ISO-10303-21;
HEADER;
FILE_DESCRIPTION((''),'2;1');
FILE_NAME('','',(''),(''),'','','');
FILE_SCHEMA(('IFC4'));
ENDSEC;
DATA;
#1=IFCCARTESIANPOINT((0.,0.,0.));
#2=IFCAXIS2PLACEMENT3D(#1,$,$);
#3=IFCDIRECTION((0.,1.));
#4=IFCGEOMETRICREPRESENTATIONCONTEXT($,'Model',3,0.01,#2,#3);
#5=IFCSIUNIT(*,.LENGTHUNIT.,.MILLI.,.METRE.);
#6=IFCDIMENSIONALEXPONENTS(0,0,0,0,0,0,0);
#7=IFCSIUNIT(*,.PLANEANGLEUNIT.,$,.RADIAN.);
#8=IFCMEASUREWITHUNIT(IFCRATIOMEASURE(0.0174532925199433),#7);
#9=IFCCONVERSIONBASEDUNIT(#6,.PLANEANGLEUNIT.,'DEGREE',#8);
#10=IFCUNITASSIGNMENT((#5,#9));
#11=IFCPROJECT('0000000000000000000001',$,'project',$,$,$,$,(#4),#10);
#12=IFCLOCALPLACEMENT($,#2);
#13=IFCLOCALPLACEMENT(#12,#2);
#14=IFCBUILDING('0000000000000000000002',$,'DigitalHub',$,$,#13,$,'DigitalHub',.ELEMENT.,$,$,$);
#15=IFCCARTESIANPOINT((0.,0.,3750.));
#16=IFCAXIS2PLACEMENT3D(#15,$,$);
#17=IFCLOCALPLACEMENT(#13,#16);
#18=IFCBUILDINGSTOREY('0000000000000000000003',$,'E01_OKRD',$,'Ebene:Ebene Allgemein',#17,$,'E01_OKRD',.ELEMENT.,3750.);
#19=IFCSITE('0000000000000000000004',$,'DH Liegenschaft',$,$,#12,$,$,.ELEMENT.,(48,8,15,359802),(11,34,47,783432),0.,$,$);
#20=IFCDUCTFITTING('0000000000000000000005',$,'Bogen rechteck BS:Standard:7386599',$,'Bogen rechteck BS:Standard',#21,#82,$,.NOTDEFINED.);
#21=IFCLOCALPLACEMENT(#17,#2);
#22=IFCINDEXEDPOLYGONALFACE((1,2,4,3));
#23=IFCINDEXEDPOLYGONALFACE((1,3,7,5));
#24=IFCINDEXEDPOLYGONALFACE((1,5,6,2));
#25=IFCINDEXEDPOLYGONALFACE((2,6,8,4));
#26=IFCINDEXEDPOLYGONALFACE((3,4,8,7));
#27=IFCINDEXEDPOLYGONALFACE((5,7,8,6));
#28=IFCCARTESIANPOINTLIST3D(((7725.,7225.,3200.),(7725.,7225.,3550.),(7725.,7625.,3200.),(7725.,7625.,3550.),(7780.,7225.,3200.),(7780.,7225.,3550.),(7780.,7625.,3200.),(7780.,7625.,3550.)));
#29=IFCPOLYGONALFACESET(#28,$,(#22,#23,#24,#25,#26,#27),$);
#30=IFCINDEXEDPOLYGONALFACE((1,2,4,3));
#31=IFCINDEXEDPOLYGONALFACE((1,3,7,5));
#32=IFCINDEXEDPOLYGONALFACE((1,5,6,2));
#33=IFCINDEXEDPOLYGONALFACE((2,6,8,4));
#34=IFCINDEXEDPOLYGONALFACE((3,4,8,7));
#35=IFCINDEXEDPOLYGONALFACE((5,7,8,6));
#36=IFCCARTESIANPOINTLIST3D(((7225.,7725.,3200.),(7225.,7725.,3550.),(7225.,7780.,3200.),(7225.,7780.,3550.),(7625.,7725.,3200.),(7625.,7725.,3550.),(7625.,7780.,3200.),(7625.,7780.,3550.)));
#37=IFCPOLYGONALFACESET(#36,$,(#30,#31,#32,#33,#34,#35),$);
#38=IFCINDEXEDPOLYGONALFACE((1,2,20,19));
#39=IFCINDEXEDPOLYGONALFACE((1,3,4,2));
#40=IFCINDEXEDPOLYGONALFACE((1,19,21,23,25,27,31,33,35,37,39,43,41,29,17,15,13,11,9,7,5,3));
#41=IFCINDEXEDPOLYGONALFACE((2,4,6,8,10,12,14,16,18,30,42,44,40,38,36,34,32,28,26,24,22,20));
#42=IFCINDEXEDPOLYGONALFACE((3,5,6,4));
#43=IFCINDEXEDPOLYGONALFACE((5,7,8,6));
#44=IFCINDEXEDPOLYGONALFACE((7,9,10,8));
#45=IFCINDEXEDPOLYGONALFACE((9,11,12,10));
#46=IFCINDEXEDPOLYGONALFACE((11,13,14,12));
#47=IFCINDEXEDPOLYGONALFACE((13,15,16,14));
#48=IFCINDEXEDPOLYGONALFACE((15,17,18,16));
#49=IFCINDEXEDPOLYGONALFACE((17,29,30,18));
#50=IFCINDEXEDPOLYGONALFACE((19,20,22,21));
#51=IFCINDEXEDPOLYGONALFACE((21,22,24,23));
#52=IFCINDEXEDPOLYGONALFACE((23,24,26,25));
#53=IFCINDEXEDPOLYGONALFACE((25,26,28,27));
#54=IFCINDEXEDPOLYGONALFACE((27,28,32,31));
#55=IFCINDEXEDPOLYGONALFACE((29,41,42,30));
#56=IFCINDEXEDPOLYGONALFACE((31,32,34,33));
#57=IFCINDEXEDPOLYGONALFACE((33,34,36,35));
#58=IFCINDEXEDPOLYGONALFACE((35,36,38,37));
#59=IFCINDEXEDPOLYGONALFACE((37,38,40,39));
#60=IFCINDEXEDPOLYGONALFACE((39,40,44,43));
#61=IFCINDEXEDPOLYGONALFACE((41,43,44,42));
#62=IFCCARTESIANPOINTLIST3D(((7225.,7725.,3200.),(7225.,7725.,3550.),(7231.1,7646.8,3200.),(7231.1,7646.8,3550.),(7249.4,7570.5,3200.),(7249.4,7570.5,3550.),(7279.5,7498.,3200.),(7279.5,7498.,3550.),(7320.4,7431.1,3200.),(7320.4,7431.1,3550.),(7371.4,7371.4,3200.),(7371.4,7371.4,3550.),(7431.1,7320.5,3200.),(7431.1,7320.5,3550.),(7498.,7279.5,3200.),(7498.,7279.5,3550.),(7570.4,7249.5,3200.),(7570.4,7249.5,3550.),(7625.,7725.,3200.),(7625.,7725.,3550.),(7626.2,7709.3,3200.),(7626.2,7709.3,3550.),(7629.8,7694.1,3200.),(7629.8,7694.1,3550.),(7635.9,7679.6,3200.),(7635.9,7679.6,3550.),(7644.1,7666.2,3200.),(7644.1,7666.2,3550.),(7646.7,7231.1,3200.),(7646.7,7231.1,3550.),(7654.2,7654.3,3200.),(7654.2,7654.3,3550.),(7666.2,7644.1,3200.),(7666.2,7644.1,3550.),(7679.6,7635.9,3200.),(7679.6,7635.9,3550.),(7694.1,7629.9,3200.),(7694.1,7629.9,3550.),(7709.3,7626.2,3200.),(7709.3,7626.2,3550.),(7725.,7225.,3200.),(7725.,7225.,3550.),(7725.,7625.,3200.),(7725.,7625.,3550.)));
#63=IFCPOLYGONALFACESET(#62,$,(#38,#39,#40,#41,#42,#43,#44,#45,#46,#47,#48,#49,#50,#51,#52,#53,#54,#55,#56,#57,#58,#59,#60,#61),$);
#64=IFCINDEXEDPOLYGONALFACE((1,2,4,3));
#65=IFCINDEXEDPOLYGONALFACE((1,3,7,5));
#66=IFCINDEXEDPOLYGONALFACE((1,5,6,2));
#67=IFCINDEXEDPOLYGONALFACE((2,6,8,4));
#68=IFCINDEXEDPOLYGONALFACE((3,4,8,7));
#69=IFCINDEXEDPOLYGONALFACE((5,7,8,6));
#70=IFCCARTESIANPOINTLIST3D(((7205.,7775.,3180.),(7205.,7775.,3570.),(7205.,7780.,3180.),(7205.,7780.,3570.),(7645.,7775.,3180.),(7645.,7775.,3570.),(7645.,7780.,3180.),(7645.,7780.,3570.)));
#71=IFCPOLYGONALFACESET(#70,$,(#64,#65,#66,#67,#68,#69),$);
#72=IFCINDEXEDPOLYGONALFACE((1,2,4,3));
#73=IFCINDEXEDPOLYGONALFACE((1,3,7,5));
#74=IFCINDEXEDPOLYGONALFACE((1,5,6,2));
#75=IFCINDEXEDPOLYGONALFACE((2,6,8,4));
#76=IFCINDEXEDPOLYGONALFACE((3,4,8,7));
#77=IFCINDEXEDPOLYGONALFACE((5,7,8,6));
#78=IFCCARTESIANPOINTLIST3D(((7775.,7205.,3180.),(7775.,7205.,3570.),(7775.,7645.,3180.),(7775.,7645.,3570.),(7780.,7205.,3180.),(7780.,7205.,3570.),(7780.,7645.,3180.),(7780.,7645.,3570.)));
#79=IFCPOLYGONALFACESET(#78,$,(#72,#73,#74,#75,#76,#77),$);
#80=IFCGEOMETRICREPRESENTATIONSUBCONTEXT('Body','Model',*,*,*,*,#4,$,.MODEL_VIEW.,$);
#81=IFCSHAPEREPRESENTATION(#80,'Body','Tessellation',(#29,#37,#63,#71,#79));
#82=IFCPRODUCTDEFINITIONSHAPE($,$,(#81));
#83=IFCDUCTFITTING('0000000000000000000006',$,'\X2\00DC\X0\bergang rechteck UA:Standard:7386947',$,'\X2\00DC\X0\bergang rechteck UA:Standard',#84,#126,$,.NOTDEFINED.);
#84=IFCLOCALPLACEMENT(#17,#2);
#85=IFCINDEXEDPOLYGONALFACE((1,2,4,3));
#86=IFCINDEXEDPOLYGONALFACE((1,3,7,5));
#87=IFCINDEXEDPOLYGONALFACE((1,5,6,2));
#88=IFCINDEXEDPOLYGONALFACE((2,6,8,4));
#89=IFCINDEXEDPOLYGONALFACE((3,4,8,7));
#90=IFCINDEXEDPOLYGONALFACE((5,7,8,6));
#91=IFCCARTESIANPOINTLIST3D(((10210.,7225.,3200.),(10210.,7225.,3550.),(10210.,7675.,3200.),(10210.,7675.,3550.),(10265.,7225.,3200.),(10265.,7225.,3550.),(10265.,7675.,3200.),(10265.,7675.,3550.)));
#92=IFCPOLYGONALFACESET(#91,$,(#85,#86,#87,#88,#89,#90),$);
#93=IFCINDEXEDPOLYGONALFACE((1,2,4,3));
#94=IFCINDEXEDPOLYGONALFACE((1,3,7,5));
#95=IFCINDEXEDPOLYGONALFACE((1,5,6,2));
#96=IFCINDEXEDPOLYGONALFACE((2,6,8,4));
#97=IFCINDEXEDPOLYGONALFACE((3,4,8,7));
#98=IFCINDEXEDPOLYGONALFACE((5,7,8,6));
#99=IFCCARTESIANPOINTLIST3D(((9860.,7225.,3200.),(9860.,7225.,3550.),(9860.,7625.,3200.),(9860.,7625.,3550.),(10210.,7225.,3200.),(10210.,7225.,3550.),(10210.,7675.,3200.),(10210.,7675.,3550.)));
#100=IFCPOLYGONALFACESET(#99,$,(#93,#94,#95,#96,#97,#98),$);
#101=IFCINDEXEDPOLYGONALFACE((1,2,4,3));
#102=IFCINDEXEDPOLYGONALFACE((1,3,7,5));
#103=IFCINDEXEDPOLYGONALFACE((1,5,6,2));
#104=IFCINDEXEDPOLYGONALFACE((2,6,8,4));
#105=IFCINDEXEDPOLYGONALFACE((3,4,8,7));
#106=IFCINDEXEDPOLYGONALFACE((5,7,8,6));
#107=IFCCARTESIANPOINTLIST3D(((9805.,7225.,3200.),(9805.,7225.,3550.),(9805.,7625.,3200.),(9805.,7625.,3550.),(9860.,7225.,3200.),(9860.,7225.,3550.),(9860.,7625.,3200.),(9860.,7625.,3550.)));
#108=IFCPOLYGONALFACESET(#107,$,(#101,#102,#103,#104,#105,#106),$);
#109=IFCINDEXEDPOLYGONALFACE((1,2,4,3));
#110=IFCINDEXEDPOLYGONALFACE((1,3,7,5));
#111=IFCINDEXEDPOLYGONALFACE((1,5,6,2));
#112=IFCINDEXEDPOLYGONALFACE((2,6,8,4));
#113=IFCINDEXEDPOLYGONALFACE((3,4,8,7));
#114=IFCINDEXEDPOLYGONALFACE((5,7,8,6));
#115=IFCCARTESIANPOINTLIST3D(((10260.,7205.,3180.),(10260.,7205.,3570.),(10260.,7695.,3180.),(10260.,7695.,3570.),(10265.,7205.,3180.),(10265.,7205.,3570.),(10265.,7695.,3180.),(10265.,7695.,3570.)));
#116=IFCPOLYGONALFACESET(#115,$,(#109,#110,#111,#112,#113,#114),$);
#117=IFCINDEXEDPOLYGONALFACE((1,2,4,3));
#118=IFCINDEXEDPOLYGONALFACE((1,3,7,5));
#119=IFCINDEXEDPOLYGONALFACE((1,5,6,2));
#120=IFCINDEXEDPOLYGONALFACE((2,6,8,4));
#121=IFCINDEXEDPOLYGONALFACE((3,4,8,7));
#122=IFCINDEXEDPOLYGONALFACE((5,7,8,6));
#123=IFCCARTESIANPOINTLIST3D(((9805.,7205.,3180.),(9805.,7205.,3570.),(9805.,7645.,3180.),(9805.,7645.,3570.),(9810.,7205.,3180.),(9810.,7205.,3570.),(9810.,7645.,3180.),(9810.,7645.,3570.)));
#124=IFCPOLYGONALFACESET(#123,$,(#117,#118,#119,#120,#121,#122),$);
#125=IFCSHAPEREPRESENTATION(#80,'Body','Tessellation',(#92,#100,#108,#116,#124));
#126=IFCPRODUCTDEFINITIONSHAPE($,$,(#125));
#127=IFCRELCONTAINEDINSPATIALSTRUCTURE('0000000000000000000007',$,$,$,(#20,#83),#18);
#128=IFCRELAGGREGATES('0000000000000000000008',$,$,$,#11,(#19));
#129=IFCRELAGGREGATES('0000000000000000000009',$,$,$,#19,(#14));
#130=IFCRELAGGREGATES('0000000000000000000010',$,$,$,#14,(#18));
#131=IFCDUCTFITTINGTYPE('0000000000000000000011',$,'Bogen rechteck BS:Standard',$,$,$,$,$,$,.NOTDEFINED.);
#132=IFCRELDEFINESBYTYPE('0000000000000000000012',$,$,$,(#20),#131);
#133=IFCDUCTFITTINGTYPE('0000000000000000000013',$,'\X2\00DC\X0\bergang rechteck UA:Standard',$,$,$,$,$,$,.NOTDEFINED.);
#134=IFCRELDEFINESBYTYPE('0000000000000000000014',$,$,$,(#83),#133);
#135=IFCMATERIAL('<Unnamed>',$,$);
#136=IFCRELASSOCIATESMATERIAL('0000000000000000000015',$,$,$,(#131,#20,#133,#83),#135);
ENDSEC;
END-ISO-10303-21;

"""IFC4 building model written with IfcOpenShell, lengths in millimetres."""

from ifc_helpers import new_model, entity, si_unit, converted_unit, direction, frame, origin, place, context, subcontext, project, spatial, indexed_curve, outline, extrude, source, transform, mapped, material, type_object, type_shapes, element, save


model = new_model("IFC4")

# Units and contexts
model_context = context("Model", 3, precision=0.01, world=origin(), true_north=direction((0.0, 1.0)))
body_context = subcontext(model_context, "Body", "Model", "MODEL_VIEW")
ifc_project = project(units=[si_unit("LENGTHUNIT", "METRE", prefix="MILLI"), converted_unit("PLANEANGLEUNIT", "DEGREE", entity("IfcRatioMeasure", 0.0174532925199433), si_unit("PLANEANGLEUNIT", "RADIAN"), dimensions=[0, 0, 0, 0, 0, 0, 0])], contexts=[model_context])

# Site, building, storey
site_placement = place(None, origin())
site = spatial("IfcSite", under=ifc_project, at=site_placement, Name="DH Liegenschaft", CompositionType="ELEMENT", RefLatitude=(48, 8, 15, 359802), RefLongitude=(11, 34, 47, 783432), RefElevation=0.0)
building_placement = place(site_placement, origin())
building = spatial("IfcBuilding", under=site, at=building_placement, Name="DigitalHub", LongName="DigitalHub", CompositionType="ELEMENT")
storey_placement = place(building_placement, frame((0.0, 0.0, 3750.0)))
storey = spatial("IfcBuildingStorey", under=building, at=storey_placement, Name="E01_OKRD", ObjectType="Ebene:Ebene Allgemein", LongName="E01_OKRD", CompositionType="ELEMENT", Elevation=3750.0)

# Shared definitions
ifc_material_1 = material(Name="<Unnamed>")

# Duct fittings
duct_fitting_type_1 = type_object("IfcDuctFittingType", Name="Bogen rechteck BS:Standard", PredefinedType="NOTDEFINED", material=ifc_material_1)
shared_shape_1 = source(origin(), body_context, "Body", "SweptSolid", [
    extrude(outline(indexed_curve([(-27.5, -200.0), (27.5, -200.0), (27.5, 200.0), (-27.5, 200.0), (-27.5, -200.0)], self_intersect=False)), frame((0.0, 327.5, -175.0), z_axis=(0.0, 0.0, 1.0), x_axis=(0.0, 1.0, 0.0)), (0.0, 0.0, 1.0), 350.0),
    extrude(outline(indexed_curve([(-200.0, -27.5), (200.0, -27.5), (200.0, 27.5), (-200.0, 27.5), (-200.0, -27.5)], self_intersect=False)), frame((-327.5, 0.0, -175.0), z_axis=(0.0, 0.0, 1.0), x_axis=(0.0, -1.0, 0.0)), (0.0, 0.0, 1.0), 350.0),
    extrude(outline(indexed_curve([(-350.0, -150.0), (50.0, -150.0), (51.2, -134.4), (54.9, -119.1), (60.9, -104.6), (69.1, -91.2), (79.3, -79.3), (91.2, -69.1), (104.6, -60.9), (119.1, -54.9), (134.4, -51.2), (150.0, -50.0), (150.0, 350.0), (71.8, 343.8), (-4.5, 325.5), (-77.0, 295.5), (-143.9, 254.5), (-203.6, 203.6), (-254.5, 143.9), (-295.5, 77.0), (-325.5, 4.5), (-343.8, -71.8), (-350.0, -150.0)], self_intersect=False)), frame((-150.0, 150.0, -175.0), z_axis=(0.0, 0.0, 1.0), x_axis=(-1.0, 0.0, 0.0)), (0.0, 0.0, 1.0), 350.0),
    extrude(outline(indexed_curve([(-2.5, -220.0), (2.5, -220.0), (2.5, 220.0), (-2.5, 220.0), (-2.5, -220.0)], self_intersect=False)), frame((-352.5, 0.0, -195.0)), (0.0, 0.0, 1.0), 390.0),
    extrude(outline(indexed_curve([(-2.5, -220.0), (2.5, -220.0), (2.5, 220.0), (-2.5, 220.0), (-2.5, -220.0)], self_intersect=False)), frame((0.0, 352.5, -195.0), z_axis=(0.0, 0.0, 1.0), x_axis=(0.0, 1.0, 0.0)), (0.0, 0.0, 1.0), 390.0),
])
type_shapes(duct_fitting_type_1, [shared_shape_1])
duct_fitting_1_placement = place(storey_placement, frame((7425.0, 7425.0, 3375.0), z_axis=(0.0, 0.0, 1.0), x_axis=(0.0, -1.0, 0.0)))
element("IfcDuctFitting", 1, at=duct_fitting_1_placement, inside=storey, type_object=duct_fitting_type_1, material=ifc_material_1, Name="Bogen rechteck BS:Standard:7386599", ObjectType="Bogen rechteck BS:Standard", PredefinedType="NOTDEFINED", context=body_context, shape_type="MappedRepresentation", body=[
    mapped(shared_shape_1, transform((0.0, 0.0, 0.0), scale=1.0)),
])
duct_fitting_type_2 = type_object("IfcDuctFittingType", Name="Übergang rechteck UA:Standard", PredefinedType="NOTDEFINED", material=ifc_material_1)
shared_shape_2 = source(origin(), body_context, "Body", "SweptSolid", [
    extrude(outline(indexed_curve([(-27.5, -225.0), (27.5, -225.0), (27.5, 225.0), (-27.5, 225.0), (-27.5, -225.0)], self_intersect=False)), frame((432.5, 25.0, -175.0)), (0.0, 0.0, 1.0), 350.0),
    extrude(outline(indexed_curve([(-175.0, -212.5), (175.0, -212.5), (175.0, 237.5), (-175.0, 187.5), (-175.0, -212.5)], self_intersect=False)), frame((230.0, 12.5, -175.0)), (0.0, 0.0, 1.0), 350.0),
    extrude(outline(indexed_curve([(-27.5, -200.0), (27.5, -200.0), (27.5, 200.0), (-27.5, 200.0), (-27.5, -200.0)], self_intersect=False)), frame((27.5, 0.0, -175.0)), (0.0, 0.0, 1.0), 350.0),
    extrude(outline(indexed_curve([(-2.5, -245.0), (2.5, -245.0), (2.5, 245.0), (-2.5, 245.0), (-2.5, -245.0)], self_intersect=False)), frame((457.5, 25.0, -195.0)), (0.0, 0.0, 1.0), 390.0),
    extrude(outline(indexed_curve([(-2.5, -220.0), (2.5, -220.0), (2.5, 220.0), (-2.5, 220.0), (-2.5, -220.0)], self_intersect=False)), frame((2.5, 0.0, -195.0)), (0.0, 0.0, 1.0), 390.0),
])
type_shapes(duct_fitting_type_2, [shared_shape_2])
duct_fitting_2_placement = place(storey_placement, frame((9805.0, 7425.0, 3375.0)))
element("IfcDuctFitting", 2, at=duct_fitting_2_placement, inside=storey, type_object=duct_fitting_type_2, material=ifc_material_1, Name="Übergang rechteck UA:Standard:7386947", ObjectType="Übergang rechteck UA:Standard", PredefinedType="NOTDEFINED", context=body_context, shape_type="MappedRepresentation", body=[
    mapped(shared_shape_2, transform((0.0, 0.0, 0.0), scale=1.0)),
])

save(model, "model.ifc")
